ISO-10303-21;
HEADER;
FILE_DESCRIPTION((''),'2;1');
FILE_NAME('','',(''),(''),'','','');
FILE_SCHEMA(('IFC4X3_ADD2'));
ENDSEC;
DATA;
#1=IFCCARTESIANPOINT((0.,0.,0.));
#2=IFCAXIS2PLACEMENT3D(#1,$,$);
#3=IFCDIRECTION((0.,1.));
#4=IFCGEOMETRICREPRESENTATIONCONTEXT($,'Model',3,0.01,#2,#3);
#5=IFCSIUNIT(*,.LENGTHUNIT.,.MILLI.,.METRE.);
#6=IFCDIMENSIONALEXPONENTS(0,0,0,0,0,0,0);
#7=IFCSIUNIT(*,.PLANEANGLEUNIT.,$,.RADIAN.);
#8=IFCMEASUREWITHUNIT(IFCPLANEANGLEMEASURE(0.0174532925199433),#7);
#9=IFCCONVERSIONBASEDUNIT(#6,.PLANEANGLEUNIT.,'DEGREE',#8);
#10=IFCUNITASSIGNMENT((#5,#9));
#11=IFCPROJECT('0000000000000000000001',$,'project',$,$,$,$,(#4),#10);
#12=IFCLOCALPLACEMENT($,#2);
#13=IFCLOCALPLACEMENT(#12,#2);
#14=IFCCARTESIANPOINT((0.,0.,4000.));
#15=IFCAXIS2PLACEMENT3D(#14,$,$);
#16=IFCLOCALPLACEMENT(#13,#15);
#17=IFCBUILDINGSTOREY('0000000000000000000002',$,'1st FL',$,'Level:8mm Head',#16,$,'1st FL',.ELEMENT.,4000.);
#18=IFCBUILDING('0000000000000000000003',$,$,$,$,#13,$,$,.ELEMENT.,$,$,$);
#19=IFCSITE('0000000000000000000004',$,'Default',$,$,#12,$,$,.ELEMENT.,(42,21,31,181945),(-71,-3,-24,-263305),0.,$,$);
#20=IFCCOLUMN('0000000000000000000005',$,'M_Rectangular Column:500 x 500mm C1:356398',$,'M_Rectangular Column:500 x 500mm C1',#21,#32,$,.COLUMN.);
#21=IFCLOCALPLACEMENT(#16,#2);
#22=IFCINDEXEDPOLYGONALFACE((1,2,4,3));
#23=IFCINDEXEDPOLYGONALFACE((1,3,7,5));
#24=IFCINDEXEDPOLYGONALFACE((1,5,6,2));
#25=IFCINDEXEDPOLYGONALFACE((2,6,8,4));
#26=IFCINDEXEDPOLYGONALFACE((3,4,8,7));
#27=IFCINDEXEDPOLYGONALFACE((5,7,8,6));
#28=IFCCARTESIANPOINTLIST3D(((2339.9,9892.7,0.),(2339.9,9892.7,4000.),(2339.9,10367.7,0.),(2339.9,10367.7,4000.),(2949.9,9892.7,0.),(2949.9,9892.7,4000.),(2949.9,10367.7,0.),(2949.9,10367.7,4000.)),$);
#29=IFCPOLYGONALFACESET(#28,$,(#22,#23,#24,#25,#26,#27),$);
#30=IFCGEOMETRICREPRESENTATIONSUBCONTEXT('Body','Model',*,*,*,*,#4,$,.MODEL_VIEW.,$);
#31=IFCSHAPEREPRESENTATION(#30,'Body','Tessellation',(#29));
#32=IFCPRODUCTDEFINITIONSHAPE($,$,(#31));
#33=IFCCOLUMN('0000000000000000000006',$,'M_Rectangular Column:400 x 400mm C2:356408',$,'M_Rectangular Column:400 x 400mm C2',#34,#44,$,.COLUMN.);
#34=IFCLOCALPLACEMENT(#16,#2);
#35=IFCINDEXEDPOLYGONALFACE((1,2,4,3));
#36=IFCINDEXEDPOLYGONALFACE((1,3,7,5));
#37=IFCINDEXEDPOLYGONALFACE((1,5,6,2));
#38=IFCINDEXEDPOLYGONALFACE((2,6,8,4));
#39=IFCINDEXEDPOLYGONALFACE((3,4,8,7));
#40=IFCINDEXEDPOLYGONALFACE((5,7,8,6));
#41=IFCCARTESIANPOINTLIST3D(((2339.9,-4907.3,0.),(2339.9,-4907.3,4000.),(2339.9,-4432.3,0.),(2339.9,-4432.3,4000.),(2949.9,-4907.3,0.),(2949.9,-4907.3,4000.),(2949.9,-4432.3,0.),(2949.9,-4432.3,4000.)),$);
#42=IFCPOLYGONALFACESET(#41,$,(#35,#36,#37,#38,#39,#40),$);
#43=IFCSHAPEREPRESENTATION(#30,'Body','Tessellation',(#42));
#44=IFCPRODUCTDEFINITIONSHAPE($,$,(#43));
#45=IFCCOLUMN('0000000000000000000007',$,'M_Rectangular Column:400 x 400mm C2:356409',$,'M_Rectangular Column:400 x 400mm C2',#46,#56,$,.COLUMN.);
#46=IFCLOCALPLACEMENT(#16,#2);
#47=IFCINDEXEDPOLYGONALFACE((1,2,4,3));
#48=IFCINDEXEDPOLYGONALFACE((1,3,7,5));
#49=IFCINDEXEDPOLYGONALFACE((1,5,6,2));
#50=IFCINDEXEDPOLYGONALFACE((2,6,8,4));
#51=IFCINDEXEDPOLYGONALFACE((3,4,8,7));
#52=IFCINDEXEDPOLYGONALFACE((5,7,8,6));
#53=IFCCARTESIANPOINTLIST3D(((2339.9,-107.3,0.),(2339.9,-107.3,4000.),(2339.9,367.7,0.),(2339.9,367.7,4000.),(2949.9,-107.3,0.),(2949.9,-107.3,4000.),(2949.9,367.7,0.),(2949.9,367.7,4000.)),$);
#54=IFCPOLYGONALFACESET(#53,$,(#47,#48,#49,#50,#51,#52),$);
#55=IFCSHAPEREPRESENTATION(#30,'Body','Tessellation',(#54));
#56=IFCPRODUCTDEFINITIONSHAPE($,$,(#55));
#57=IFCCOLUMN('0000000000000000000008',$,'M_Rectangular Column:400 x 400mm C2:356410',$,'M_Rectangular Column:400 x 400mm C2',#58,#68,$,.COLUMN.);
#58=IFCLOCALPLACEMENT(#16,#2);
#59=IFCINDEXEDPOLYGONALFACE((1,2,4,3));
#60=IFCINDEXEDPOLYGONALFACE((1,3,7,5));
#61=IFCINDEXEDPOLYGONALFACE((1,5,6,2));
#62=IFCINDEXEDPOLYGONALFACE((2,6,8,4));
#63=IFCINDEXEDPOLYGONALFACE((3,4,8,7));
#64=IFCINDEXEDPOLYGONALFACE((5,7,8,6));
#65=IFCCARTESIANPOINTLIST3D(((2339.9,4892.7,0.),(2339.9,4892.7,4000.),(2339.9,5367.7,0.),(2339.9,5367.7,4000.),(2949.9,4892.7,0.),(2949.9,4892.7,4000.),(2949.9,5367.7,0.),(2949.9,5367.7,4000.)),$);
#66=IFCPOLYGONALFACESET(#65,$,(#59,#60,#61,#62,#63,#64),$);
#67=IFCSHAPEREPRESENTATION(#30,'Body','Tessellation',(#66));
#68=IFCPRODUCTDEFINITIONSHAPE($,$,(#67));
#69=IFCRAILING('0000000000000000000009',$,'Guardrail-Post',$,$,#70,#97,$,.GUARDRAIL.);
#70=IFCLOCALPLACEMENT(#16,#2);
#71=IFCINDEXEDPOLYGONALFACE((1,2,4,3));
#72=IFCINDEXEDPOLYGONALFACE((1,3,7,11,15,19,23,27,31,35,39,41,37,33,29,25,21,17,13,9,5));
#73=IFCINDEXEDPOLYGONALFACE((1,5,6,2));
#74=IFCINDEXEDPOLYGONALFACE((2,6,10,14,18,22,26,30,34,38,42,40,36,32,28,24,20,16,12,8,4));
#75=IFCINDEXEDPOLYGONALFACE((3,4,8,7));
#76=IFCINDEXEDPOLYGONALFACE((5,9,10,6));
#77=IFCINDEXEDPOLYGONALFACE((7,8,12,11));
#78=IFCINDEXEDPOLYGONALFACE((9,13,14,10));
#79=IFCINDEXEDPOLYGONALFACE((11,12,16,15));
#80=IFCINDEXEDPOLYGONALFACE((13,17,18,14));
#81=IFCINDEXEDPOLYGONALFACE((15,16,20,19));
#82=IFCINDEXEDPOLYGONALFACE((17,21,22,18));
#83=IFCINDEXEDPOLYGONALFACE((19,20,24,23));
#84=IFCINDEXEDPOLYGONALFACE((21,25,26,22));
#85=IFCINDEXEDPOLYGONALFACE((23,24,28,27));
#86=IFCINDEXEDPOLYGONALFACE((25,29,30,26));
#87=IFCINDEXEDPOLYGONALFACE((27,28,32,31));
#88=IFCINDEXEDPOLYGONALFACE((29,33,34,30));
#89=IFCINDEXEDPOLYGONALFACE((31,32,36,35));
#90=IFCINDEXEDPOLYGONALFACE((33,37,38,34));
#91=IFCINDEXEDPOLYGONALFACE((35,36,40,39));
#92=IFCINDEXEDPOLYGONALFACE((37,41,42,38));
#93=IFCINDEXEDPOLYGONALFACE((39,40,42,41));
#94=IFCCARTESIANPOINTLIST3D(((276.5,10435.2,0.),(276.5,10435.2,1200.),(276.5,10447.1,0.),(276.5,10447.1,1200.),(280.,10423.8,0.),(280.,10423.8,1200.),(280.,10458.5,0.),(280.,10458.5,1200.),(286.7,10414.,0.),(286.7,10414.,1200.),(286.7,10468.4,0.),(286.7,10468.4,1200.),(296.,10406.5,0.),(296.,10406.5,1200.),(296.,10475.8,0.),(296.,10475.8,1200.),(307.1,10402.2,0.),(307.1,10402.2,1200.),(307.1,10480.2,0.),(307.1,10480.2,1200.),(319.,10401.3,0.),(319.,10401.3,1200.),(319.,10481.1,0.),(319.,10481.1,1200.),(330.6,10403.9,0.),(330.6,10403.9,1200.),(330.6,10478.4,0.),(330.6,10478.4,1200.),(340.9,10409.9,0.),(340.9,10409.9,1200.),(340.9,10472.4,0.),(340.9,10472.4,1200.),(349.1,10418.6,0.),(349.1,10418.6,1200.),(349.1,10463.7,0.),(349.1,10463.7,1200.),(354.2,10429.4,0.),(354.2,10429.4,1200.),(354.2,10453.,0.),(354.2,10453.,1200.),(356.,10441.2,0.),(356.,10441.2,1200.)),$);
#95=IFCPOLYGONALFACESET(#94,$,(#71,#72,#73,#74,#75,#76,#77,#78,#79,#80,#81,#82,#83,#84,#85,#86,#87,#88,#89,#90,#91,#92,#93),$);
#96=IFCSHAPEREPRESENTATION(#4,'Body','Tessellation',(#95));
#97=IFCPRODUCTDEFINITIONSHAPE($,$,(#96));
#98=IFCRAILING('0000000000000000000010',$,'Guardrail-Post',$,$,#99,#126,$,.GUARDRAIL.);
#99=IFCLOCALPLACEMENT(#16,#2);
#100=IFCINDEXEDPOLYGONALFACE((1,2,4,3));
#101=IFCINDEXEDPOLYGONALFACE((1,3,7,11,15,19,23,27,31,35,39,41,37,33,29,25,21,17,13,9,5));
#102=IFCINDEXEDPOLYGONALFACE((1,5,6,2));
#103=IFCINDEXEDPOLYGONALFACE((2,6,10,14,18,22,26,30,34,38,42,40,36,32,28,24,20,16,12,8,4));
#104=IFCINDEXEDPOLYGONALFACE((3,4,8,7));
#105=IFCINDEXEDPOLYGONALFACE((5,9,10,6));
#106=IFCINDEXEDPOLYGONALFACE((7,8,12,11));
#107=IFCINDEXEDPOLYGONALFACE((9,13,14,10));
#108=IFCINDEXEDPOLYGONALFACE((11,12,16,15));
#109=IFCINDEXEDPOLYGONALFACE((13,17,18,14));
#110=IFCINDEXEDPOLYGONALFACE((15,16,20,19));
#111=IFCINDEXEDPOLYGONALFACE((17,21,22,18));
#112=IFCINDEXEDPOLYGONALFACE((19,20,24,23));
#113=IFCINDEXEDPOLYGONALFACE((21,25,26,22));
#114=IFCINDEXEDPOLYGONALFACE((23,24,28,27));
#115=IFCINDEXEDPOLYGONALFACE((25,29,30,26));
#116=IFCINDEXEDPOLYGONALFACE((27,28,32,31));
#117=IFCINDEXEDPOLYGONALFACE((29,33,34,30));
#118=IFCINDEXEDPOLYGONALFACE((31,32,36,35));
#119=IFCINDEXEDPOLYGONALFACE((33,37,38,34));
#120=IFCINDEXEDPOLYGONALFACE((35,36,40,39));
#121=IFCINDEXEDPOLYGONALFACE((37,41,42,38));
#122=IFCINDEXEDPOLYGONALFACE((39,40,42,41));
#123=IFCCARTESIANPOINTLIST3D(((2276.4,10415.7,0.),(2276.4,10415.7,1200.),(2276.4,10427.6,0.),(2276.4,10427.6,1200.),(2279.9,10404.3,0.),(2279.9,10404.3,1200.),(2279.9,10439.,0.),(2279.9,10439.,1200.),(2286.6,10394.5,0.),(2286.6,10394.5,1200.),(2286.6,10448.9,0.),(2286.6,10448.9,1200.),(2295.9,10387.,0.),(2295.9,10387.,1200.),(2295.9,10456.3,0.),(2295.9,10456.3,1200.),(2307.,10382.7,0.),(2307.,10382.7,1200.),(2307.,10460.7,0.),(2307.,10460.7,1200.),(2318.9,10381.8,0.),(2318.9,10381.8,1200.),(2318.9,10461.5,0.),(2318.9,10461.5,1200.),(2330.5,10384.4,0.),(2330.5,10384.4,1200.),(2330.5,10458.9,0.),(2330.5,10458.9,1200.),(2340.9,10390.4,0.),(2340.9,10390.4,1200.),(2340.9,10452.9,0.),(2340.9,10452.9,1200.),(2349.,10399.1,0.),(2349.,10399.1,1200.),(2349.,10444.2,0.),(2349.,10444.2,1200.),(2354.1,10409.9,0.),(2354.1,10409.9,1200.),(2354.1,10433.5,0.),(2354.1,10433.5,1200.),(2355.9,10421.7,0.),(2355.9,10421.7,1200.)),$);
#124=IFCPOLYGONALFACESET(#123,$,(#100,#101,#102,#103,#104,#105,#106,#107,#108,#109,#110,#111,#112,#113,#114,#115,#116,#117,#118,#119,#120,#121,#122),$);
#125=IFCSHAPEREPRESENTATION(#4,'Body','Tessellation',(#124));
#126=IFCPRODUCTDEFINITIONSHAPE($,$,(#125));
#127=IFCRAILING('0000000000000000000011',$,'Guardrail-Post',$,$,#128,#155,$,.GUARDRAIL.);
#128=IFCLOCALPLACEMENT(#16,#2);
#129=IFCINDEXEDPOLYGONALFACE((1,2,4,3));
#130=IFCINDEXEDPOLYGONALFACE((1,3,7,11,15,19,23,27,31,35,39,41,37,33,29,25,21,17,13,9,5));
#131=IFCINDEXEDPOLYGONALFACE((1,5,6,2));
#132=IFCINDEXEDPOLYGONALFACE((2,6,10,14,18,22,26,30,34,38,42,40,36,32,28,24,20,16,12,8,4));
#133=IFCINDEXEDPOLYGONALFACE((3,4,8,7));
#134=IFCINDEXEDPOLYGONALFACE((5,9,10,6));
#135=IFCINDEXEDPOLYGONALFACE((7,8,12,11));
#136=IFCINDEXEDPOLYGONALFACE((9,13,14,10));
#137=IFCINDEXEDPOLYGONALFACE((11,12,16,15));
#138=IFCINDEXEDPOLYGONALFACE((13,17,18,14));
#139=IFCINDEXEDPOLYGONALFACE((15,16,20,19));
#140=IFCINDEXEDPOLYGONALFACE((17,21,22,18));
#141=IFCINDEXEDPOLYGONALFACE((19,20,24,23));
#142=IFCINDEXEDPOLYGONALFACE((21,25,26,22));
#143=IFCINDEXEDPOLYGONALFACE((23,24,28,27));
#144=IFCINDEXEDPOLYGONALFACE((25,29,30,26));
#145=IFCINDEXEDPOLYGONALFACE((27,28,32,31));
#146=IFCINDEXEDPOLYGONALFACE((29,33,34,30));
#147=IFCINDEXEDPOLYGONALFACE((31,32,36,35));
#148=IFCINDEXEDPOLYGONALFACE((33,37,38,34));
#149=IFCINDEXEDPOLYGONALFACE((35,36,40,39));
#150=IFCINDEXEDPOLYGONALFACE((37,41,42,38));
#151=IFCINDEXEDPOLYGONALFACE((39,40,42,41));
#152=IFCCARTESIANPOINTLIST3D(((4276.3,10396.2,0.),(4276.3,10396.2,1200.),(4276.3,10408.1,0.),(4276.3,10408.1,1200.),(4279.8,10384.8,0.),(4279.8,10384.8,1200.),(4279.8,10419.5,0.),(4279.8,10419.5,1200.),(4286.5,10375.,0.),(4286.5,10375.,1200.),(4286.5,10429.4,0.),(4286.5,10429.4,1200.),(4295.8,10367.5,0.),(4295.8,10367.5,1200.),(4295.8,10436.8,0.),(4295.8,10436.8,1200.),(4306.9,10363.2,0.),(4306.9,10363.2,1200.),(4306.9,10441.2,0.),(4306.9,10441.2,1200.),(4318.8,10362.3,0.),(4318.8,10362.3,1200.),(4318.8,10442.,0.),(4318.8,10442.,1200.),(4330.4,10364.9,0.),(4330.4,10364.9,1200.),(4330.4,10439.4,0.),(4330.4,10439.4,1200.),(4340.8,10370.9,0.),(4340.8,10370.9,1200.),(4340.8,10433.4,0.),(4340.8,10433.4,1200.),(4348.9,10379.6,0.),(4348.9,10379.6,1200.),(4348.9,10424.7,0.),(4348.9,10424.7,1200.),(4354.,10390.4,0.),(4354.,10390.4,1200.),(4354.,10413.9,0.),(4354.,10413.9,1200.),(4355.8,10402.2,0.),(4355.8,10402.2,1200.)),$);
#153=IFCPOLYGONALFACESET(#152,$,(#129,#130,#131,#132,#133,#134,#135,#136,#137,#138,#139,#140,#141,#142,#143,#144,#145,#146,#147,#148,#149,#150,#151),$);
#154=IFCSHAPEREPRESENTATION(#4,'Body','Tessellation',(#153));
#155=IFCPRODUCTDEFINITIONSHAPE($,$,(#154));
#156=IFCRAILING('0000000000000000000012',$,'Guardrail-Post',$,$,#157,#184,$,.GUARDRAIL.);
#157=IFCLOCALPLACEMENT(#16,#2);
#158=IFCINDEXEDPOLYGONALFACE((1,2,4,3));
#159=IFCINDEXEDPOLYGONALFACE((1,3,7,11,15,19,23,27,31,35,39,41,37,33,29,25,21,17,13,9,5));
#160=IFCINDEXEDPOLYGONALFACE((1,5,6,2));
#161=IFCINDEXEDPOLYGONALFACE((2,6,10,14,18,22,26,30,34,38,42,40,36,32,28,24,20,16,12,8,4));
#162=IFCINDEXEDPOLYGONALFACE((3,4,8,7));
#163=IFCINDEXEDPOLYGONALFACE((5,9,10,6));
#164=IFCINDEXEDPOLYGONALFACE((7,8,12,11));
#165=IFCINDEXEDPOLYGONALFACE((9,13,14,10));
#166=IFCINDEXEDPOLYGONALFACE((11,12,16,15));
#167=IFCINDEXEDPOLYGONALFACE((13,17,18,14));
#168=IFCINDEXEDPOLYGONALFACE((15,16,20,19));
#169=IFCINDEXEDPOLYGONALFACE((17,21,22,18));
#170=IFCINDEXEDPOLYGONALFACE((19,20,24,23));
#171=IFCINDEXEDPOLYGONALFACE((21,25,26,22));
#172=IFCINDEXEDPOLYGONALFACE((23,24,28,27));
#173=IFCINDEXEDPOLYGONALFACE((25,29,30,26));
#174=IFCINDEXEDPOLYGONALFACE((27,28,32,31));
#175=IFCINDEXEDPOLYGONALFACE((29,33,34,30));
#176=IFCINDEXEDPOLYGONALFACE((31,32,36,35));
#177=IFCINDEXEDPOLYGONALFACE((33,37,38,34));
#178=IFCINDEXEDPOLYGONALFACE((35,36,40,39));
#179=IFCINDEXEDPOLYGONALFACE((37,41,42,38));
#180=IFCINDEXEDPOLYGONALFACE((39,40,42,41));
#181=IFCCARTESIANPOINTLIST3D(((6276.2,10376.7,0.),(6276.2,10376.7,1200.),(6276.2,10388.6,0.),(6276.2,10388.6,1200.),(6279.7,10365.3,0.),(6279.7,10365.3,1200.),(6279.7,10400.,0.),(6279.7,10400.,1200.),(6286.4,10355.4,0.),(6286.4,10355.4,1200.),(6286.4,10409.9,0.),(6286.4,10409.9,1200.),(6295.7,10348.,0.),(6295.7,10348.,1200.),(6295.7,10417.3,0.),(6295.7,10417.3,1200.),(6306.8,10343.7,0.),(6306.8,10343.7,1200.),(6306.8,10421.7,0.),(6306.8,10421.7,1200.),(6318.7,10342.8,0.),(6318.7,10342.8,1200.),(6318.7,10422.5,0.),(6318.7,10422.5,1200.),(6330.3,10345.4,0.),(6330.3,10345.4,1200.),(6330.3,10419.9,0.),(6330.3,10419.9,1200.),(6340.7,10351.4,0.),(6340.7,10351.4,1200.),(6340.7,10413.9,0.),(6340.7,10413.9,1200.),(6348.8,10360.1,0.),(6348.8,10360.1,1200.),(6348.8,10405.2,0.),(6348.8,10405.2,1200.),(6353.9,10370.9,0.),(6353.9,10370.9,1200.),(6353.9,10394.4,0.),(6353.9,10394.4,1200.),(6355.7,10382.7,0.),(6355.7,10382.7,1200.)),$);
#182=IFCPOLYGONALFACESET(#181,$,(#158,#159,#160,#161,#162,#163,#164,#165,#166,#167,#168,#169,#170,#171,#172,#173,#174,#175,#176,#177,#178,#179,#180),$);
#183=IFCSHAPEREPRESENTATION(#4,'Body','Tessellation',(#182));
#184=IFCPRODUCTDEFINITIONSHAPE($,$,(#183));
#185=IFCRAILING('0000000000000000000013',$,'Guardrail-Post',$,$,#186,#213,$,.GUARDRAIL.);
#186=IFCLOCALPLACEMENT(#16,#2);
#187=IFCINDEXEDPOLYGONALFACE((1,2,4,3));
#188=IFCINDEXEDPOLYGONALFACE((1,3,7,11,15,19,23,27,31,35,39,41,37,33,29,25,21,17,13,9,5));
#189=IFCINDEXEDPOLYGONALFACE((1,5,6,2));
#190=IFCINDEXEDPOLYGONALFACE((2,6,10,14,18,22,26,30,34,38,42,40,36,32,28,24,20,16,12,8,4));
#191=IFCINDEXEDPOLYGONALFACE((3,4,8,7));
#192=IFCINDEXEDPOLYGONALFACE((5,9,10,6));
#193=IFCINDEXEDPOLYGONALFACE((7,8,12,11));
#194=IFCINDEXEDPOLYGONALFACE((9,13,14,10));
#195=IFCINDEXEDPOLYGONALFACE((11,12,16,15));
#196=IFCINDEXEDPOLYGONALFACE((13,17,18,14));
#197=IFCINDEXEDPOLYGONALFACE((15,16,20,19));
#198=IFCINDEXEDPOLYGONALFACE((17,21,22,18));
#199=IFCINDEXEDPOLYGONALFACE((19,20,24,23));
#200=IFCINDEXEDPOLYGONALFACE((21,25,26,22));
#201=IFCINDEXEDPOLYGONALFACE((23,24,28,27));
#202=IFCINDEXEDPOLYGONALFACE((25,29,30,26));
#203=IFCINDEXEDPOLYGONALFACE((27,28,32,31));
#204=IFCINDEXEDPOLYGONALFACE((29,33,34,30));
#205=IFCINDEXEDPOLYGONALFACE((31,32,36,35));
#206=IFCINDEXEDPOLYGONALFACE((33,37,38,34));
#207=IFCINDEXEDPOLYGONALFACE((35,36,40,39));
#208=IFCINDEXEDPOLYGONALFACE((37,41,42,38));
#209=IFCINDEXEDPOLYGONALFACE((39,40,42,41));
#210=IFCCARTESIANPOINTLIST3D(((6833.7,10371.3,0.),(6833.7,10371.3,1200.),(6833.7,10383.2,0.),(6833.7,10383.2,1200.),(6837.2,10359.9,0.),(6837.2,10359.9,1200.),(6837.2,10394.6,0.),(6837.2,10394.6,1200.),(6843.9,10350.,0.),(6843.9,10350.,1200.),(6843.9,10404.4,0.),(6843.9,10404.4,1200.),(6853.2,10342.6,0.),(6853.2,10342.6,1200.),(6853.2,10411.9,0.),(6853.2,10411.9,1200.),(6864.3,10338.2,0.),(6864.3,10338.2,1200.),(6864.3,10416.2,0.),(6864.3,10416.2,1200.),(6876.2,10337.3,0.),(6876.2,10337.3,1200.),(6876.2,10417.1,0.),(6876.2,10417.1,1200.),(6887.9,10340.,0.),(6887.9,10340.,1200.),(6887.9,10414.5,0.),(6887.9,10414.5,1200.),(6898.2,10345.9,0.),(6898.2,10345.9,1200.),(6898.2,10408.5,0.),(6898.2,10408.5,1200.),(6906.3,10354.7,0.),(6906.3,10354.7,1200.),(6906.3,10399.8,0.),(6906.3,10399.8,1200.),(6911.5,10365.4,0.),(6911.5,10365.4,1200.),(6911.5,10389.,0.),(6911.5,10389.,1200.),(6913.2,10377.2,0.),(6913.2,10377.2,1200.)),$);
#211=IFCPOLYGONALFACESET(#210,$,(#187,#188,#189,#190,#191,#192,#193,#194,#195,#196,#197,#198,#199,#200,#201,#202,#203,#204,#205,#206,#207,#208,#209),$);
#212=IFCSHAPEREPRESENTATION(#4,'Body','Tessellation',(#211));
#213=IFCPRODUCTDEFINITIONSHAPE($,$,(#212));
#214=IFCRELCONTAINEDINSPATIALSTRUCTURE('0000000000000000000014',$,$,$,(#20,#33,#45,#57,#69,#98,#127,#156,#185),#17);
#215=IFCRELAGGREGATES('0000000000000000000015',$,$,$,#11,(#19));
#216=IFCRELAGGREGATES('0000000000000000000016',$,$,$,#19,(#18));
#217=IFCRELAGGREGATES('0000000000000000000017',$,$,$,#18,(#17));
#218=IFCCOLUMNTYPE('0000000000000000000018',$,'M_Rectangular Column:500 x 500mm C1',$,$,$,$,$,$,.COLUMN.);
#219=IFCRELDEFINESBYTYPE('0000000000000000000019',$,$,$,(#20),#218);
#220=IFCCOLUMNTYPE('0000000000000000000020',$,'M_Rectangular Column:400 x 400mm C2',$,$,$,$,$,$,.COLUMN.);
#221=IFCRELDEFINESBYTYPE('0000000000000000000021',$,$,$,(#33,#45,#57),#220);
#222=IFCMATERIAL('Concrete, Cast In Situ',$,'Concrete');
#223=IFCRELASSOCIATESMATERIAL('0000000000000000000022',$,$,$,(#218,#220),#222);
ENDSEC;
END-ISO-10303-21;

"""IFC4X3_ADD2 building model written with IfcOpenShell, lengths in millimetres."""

from ifc_helpers import new_model, entity, si_unit, converted_unit, direction, frame, frame_2d, origin, origin_with_axes, origin_2d, origin_2d_with_axis, place, context, subcontext, project, spatial, rectangle, circle, extrude, source, transform, mapped, material, material_profile, profile_set, type_object, type_shapes, element, save


model = new_model("IFC4X3_ADD2")

# Units and contexts
model_context = context("Model", 3, precision=0.01, world=origin(), true_north=direction((0.0, 1.0)))
body_context = subcontext(model_context, "Body", "Model", "MODEL_VIEW")
ifc_project = project(units=[si_unit("LENGTHUNIT", "METRE", prefix="MILLI"), converted_unit("PLANEANGLEUNIT", "DEGREE", entity("IfcPlaneAngleMeasure", 0.0174532925199433), si_unit("PLANEANGLEUNIT", "RADIAN"), dimensions=[0, 0, 0, 0, 0, 0, 0])], contexts=[model_context])

# Site, building, storey
site_placement = place(None, origin())
site = spatial("IfcSite", under=ifc_project, at=site_placement, Name="Default", CompositionType="ELEMENT", RefLatitude=(42, 21, 31, 181945), RefLongitude=(-71, -3, -24, -263305), RefElevation=0.0)
building_placement = place(site_placement, origin())
building = spatial("IfcBuilding", under=site, at=building_placement, CompositionType="ELEMENT")
storey_placement = place(building_placement, frame((0.0, 0.0, 4000.0)))
storey = spatial("IfcBuildingStorey", under=building, at=storey_placement, Name="1st FL", ObjectType="Level:8mm Head", LongName="1st FL", CompositionType="ELEMENT", Elevation=4000.0)

# Columns
ifc_material = material(Name="Concrete, Cast In Situ", Category="Concrete")
ifc_material_profile_1 = material_profile(ifc_material, rectangle(XDim=610.0, YDim=475.0, at=frame_2d((0.0, 0.0), x_axis=(1.0, 0.0))), Name="500 x 500mm C1")
ifc_profile_set_1 = profile_set([ifc_material_profile_1], Name="500 x 500mm C1")
column_type_1 = type_object("IfcColumnType", Name="M_Rectangular Column:500 x 500mm C1", PredefinedType="COLUMN", material=ifc_profile_set_1)
shared_shape_1 = source(origin(), body_context, "Body", "SweptSolid", [
    extrude(rectangle(XDim=610.0, YDim=475.0, at=origin_2d_with_axis()), frame((0.0, 0.0, 4000.0), z_axis=(0.0, 0.0, 1.0), x_axis=(-1.0, 0.0, 0.0)), (0.0, 0.0, 1.0), 4000.0),
])
type_shapes(column_type_1, [shared_shape_1])
column_placement = place(storey_placement, frame((2644.9, 10130.2, -4000.0)))
element("IfcColumn", 1, at=column_placement, inside=storey, type_object=column_type_1, Name="M_Rectangular Column:500 x 500mm C1:356398", ObjectType="M_Rectangular Column:500 x 500mm C1", PredefinedType="COLUMN", context=body_context, shape_type="MappedRepresentation", body=[
    mapped(shared_shape_1, transform((0.0, 0.0, 0.0), scale=1.0)),
])
ifc_material_profile_2 = material_profile(ifc_material, rectangle(XDim=610.0, YDim=475.0, at=origin_2d_with_axis()), Name="400 x 400mm C2")
ifc_profile_set_2 = profile_set([ifc_material_profile_2], Name="400 x 400mm C2")
column_type_2 = type_object("IfcColumnType", Name="M_Rectangular Column:400 x 400mm C2", PredefinedType="COLUMN", material=ifc_profile_set_2)
shared_shape_2 = source(origin(), body_context, "Body", "SweptSolid", [
    extrude(rectangle(XDim=610.0, YDim=475.0, at=origin_2d_with_axis()), frame((0.0, 0.0, 4000.0), z_axis=(0.0, 0.0, 1.0), x_axis=(-1.0, 0.0, 0.0)), (0.0, 0.0, 1.0), 4000.0),
])
type_shapes(column_type_2, [shared_shape_2])
for number, where, name in (
    (2, (2644.9, -4669.8, -4000.0), "M_Rectangular Column:400 x 400mm C2:356408"),
    (3, (2644.9, 130.2, -4000.0), "M_Rectangular Column:400 x 400mm C2:356409"),
    (4, (2644.9, 5130.2, -4000.0), "M_Rectangular Column:400 x 400mm C2:356410"),
):
    element("IfcColumn", number, at=place(storey_placement, frame(where)), inside=storey, type_object=column_type_2, Name=name, ObjectType="M_Rectangular Column:400 x 400mm C2", PredefinedType="COLUMN", context=body_context, shape_type="MappedRepresentation", body=[
        mapped(shared_shape_2, transform((0.0, 0.0, 0.0), scale=1.0)),
    ])

# Railings
for number, where, z_axis, x_axis, name in (
    (5, (316.0, 10441.2, 4000.0), (0.0, 0.0, 1.0), (1.0, 0.0, 0.0), "Guardrail-Post"),
    (6, (2315.9, 10421.7, 4000.0), (0.0, 0.0, 1.0), (1.0, 0.0, 0.0), "Guardrail-Post"),
    (7, (4315.8, 10402.2, 4000.0), (0.0, 0.0, 1.0), (1.0, 0.0, 0.0), "Guardrail-Post"),
    (8, (6315.7, 10382.7, 4000.0), (0.0, 0.0, 1.0), (1.0, 0.0, 0.0), "Guardrail-Post"),
    (9, (6873.2, 10377.2, 4000.0), (0.0, 0.0, 1.0), (1.0, 0.0, 0.0), "Guardrail-Post"),
):
    element("IfcRailing", number, at=place(None, frame(where, z_axis=z_axis, x_axis=x_axis)), inside=storey, Name=name, PredefinedType="GUARDRAIL", context=model_context, shape_type="SweptSolid", body=[
        extrude(circle(Radius=40.0, at=origin_2d()), origin_with_axes(), (0.0, 0.0, 1.0), 1200.0),
    ])

save(model, "model.ifc")
